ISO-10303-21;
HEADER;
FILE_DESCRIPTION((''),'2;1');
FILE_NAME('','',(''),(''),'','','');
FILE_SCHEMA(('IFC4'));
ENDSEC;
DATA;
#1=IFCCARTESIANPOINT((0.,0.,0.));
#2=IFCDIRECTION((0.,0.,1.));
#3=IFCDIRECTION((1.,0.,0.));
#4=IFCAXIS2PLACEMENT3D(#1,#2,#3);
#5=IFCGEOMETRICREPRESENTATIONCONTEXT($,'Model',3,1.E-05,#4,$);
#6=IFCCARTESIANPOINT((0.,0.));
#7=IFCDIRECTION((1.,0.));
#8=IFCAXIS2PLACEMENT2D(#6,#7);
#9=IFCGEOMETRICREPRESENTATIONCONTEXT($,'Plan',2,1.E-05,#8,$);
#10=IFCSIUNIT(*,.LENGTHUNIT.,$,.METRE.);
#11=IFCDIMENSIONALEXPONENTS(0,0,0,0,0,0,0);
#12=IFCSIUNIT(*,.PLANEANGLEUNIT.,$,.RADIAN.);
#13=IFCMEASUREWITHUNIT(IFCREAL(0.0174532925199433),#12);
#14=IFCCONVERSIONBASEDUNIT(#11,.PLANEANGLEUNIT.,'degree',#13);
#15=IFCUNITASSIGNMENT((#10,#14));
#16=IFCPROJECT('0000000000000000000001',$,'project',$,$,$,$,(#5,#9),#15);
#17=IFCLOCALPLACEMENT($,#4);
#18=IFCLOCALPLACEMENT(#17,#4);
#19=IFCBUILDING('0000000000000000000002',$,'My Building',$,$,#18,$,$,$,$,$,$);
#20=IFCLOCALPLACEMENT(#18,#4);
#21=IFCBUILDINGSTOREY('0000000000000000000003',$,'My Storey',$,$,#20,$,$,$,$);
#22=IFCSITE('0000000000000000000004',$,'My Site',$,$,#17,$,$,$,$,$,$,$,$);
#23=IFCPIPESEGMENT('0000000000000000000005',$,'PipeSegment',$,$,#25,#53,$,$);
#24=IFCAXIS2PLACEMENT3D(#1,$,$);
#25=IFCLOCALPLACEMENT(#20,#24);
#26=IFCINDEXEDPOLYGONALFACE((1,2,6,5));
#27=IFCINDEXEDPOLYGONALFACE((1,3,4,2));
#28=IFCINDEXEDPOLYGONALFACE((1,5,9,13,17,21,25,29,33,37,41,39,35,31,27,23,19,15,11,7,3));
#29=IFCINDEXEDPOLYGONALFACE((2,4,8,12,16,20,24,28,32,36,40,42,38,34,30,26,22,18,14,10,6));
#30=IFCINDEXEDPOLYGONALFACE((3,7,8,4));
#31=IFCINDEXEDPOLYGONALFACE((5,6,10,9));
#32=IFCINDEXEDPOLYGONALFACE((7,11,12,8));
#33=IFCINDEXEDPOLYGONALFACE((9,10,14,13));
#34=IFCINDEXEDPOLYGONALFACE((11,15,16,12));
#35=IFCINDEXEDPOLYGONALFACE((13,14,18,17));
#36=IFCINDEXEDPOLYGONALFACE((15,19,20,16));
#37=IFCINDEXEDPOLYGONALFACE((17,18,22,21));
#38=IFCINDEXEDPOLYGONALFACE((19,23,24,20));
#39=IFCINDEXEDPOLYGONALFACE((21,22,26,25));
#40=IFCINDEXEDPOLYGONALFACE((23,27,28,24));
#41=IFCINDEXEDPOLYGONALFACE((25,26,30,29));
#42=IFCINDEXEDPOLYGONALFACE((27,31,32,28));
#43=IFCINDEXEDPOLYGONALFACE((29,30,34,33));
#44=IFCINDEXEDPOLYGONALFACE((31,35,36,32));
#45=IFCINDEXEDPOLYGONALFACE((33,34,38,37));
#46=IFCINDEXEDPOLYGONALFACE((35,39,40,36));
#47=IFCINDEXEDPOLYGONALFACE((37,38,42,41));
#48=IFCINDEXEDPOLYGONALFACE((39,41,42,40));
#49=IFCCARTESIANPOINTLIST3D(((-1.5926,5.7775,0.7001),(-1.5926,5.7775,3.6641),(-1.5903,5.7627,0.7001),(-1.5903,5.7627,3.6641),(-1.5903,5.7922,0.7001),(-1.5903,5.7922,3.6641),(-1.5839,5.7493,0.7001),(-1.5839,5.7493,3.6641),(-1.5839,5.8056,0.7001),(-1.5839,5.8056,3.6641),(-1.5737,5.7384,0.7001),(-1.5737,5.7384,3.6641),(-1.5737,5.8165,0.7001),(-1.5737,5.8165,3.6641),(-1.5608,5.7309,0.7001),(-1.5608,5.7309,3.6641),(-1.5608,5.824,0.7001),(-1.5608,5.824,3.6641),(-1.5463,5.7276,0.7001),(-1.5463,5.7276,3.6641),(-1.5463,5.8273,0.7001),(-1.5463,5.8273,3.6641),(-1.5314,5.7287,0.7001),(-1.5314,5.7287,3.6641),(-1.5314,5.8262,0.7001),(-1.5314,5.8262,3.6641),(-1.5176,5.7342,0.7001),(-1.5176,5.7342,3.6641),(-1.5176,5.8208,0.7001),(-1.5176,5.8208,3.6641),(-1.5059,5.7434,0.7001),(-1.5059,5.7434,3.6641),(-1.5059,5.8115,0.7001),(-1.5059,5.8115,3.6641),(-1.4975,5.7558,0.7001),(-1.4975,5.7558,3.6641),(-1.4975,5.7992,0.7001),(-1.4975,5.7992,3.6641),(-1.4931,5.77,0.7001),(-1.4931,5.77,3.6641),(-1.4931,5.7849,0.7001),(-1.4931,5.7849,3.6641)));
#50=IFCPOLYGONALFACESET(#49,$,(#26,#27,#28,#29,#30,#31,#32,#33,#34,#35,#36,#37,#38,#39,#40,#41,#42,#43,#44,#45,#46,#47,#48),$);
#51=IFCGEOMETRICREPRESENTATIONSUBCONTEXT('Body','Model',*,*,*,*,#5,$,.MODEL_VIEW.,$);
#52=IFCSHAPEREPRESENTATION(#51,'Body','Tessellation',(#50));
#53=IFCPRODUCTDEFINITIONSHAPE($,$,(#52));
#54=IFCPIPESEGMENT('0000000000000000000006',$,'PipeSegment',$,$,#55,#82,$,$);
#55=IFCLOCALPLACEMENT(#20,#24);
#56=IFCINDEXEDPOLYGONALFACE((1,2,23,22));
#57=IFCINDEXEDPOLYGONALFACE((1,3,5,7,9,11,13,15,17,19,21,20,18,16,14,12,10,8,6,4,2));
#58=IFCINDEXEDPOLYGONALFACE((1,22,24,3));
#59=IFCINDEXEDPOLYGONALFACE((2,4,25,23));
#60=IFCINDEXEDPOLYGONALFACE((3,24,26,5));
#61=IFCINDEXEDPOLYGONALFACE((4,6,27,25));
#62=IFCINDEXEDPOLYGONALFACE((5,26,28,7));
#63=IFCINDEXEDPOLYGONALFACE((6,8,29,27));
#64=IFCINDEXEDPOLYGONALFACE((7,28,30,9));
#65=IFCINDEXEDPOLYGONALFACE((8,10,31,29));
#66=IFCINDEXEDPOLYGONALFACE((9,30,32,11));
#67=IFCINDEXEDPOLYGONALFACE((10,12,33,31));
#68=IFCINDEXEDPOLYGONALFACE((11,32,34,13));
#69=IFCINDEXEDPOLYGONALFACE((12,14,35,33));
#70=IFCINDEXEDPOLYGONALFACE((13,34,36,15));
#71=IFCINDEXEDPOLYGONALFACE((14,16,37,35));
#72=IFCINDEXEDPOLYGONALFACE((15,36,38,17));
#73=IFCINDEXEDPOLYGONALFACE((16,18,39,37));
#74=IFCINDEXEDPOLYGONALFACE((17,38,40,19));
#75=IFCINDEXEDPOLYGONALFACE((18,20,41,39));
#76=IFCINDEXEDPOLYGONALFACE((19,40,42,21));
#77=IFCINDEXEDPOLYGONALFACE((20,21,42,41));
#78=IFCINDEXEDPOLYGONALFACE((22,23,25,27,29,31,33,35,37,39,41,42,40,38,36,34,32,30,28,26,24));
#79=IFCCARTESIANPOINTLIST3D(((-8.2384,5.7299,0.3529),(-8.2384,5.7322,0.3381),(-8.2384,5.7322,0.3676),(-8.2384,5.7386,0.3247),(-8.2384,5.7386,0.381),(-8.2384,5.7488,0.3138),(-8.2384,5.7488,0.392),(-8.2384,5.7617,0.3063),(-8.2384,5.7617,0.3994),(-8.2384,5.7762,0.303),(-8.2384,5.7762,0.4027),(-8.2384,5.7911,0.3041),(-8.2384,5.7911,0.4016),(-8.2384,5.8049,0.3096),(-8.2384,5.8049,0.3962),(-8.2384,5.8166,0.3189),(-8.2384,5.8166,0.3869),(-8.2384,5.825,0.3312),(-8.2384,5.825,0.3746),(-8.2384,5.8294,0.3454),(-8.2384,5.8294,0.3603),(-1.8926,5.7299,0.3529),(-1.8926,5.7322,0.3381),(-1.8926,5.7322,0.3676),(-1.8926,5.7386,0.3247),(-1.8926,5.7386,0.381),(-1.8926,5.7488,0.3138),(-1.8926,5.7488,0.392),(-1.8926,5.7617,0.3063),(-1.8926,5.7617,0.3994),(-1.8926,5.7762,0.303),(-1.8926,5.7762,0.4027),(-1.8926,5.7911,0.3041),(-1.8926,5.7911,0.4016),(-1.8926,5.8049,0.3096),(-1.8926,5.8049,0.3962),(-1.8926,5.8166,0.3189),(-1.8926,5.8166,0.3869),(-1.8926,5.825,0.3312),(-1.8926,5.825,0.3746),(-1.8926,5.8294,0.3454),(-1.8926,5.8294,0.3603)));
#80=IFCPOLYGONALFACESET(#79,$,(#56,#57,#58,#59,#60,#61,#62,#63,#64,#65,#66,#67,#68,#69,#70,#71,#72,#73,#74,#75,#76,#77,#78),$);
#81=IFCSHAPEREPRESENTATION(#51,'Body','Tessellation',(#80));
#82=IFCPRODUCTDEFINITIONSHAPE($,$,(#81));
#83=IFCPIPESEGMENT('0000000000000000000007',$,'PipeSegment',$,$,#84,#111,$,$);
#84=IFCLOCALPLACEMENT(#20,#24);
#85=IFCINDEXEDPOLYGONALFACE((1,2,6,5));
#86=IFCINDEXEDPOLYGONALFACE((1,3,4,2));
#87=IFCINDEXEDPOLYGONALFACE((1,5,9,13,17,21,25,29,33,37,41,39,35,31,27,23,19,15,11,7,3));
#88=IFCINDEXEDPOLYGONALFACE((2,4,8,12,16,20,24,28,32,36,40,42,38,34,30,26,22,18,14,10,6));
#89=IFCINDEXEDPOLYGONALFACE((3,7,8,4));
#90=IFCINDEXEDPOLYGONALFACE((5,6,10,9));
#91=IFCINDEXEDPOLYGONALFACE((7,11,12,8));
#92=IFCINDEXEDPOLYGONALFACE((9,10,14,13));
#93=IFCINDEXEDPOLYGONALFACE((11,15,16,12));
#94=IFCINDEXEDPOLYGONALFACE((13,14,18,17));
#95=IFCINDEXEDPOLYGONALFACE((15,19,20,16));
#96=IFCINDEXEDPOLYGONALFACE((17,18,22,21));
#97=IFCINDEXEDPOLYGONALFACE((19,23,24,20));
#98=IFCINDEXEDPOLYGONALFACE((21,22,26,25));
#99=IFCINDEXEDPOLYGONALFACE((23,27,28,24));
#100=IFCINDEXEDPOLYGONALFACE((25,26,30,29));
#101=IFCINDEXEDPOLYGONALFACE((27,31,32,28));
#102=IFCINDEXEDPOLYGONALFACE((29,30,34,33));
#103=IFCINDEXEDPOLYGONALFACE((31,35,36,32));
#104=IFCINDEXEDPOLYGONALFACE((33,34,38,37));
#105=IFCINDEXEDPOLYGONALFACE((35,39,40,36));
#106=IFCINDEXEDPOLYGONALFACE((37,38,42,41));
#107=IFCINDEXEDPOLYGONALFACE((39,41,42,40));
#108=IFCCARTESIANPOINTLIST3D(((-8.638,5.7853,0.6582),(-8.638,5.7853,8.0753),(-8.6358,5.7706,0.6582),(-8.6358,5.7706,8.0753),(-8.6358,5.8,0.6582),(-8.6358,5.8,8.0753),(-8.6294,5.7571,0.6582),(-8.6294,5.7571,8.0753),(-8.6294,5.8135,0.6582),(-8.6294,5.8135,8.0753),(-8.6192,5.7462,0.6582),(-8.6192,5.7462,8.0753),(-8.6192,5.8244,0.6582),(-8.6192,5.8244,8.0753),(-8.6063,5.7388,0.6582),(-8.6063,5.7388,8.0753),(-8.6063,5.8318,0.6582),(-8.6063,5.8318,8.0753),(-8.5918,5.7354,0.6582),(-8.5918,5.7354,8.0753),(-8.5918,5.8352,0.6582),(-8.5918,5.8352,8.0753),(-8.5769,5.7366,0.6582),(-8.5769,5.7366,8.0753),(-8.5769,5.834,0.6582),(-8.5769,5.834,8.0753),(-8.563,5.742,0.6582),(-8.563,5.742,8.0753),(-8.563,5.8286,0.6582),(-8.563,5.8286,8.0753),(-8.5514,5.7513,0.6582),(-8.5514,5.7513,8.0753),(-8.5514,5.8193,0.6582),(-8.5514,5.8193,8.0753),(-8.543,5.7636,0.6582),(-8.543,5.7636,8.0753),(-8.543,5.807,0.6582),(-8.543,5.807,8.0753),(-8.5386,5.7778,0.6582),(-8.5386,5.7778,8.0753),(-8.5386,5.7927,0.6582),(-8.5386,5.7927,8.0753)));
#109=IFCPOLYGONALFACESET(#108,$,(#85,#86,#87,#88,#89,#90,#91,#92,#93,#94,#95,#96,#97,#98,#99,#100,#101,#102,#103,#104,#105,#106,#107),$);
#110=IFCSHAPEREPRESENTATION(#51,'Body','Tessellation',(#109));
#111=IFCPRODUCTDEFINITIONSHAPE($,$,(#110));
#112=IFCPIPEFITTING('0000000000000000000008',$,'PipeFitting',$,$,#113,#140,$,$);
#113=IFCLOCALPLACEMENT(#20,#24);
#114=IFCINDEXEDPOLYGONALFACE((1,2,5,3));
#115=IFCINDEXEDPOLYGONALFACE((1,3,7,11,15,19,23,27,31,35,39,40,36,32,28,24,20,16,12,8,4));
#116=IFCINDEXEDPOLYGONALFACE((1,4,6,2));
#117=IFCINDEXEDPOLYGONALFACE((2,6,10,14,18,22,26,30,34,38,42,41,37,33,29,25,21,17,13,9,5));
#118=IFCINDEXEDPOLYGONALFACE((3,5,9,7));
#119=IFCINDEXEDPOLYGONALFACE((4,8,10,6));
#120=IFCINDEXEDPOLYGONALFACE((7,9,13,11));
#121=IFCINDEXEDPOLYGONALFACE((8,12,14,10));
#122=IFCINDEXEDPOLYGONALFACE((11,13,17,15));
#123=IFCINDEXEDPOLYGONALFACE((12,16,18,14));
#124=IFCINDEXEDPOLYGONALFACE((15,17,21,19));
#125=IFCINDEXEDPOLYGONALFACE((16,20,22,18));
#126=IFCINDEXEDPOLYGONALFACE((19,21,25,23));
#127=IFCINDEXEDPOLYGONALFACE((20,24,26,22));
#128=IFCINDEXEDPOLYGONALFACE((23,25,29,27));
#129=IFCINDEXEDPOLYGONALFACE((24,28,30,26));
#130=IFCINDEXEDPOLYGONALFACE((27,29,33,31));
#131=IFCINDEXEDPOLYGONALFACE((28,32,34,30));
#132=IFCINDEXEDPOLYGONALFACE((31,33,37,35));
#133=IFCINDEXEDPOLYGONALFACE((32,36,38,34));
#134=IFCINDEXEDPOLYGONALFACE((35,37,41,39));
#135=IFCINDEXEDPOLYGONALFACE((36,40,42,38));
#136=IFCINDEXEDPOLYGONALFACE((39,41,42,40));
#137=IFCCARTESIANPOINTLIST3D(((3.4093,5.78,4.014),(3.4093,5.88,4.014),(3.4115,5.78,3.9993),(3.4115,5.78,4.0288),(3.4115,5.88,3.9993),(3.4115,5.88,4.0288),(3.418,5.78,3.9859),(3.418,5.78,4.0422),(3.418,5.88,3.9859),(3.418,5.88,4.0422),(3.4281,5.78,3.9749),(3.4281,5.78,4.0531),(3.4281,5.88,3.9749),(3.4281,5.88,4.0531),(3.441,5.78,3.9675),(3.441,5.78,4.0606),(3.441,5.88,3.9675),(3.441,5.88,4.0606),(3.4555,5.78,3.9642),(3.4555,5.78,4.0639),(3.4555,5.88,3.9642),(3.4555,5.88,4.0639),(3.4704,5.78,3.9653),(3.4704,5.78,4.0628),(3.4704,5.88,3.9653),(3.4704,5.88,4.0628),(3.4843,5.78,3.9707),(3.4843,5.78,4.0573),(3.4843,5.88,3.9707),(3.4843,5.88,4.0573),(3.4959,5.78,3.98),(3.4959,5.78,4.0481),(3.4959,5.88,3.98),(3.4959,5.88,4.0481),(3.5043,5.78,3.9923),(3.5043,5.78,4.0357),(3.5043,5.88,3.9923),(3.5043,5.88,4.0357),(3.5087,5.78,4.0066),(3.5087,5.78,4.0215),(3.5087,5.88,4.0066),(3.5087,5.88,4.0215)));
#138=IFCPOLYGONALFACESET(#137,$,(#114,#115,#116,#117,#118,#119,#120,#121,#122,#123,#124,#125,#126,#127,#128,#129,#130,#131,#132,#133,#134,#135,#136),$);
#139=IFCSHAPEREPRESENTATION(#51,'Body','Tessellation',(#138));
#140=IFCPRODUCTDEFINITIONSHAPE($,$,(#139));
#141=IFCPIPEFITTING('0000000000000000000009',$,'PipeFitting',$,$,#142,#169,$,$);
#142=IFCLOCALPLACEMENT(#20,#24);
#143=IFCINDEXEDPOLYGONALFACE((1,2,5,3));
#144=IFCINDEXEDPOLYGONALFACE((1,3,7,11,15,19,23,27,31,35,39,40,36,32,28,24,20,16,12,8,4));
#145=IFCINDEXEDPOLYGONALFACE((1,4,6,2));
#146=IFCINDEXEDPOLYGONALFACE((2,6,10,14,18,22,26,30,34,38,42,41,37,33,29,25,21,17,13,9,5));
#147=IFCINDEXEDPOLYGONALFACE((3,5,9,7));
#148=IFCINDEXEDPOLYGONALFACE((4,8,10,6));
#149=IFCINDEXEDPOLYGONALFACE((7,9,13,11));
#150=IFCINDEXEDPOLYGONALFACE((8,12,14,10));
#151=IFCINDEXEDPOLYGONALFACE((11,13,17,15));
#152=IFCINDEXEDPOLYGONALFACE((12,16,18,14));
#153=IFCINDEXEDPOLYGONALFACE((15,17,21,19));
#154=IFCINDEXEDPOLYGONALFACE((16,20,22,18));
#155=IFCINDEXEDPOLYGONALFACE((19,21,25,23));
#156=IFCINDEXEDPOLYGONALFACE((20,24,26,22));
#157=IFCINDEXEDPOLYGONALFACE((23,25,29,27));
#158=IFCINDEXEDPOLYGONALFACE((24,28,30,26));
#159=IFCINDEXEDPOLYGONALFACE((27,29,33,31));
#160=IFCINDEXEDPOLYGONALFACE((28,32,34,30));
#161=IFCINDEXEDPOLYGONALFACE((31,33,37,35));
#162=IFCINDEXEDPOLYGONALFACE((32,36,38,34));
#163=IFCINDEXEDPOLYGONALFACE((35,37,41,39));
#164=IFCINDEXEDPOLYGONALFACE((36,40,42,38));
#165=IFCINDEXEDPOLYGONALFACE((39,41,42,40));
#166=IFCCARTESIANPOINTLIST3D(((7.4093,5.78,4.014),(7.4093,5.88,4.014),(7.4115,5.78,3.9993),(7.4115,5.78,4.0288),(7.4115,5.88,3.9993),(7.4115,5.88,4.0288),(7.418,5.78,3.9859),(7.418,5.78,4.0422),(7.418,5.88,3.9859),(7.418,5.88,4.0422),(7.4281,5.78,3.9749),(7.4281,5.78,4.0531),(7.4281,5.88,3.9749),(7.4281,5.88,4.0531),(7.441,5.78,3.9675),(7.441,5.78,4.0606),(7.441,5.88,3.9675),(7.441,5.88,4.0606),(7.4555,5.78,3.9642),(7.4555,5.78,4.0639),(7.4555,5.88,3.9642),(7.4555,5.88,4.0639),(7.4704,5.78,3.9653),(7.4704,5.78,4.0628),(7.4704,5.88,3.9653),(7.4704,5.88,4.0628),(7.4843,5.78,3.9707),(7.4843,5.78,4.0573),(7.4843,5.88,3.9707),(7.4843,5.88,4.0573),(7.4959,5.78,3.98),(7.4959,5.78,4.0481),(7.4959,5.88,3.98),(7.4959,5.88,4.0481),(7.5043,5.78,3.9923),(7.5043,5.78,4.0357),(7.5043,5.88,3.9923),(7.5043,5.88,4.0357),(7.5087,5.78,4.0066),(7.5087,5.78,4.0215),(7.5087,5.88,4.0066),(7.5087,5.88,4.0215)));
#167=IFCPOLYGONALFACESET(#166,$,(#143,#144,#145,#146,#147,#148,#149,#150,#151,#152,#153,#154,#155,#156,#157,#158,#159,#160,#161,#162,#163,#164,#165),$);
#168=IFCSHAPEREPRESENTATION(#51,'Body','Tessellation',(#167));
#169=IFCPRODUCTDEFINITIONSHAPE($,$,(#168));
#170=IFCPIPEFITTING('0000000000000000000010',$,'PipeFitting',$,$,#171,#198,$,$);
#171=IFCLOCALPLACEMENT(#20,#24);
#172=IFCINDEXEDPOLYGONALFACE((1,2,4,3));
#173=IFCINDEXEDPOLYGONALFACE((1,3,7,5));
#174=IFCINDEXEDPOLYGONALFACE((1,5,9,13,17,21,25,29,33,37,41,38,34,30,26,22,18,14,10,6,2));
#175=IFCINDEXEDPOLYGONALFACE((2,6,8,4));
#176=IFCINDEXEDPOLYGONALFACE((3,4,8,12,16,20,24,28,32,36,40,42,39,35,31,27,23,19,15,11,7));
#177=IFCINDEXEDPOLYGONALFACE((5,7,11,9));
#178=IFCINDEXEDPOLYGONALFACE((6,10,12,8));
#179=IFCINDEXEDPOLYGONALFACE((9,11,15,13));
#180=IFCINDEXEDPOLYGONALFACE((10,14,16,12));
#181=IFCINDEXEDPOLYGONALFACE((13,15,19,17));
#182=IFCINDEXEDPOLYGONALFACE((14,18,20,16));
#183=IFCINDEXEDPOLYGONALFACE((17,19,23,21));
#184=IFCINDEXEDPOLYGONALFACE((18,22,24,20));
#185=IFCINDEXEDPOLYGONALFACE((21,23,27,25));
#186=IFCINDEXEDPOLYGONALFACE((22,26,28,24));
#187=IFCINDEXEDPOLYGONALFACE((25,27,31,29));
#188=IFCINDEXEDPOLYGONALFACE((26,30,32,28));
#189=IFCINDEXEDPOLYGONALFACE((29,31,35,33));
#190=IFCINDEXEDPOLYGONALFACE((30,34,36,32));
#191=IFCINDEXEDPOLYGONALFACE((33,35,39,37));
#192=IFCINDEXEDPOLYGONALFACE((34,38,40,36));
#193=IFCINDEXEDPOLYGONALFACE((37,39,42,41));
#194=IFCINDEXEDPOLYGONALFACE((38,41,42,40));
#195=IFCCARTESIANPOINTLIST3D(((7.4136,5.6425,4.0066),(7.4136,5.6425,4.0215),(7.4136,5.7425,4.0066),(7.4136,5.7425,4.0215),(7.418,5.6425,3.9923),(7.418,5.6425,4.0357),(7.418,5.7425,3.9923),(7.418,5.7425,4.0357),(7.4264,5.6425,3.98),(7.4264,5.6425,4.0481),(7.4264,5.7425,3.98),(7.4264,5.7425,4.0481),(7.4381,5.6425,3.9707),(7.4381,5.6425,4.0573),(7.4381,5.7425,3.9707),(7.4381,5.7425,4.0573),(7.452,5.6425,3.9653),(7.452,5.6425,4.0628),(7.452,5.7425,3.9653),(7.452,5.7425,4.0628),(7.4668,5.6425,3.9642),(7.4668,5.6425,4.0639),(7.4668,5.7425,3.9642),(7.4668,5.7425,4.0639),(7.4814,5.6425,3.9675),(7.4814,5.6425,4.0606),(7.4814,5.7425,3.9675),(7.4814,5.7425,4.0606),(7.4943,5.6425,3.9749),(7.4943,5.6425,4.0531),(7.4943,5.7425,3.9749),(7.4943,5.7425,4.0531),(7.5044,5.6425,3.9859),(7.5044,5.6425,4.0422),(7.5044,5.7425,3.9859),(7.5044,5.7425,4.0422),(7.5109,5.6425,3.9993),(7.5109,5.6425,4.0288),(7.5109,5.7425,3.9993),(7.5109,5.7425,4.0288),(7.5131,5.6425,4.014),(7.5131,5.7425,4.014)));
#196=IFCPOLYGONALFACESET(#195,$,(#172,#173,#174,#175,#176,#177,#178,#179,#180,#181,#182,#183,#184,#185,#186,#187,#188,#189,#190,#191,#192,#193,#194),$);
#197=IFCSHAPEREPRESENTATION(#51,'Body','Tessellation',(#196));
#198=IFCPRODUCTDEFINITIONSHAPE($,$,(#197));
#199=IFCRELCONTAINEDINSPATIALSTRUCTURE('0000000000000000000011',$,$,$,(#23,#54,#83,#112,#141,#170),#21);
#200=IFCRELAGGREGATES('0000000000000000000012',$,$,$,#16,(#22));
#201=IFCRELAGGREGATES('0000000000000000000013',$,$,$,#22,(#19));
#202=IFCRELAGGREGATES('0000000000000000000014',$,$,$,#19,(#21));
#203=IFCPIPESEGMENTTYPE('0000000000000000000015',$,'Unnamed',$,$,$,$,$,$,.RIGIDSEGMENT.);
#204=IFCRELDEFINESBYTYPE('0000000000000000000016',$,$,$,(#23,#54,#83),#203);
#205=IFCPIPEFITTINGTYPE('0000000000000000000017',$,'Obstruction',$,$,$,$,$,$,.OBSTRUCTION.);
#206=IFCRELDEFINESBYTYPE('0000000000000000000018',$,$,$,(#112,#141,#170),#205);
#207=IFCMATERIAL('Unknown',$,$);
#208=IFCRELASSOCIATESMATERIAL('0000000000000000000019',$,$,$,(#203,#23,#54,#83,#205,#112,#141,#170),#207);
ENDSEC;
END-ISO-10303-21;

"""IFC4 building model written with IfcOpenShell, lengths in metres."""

from ifc_helpers import new_model, entity, si_unit, converted_unit, frame, origin_with_axes, origin_2d_with_axis, place, context, subcontext, project, spatial, circle, extrude, material, material_profile, profile_set, profile_usage, type_object, element, save


model = new_model("IFC4")

# Units and contexts
model_context = context("Model", 3, precision=1e-05, world=origin_with_axes())
plan_context = context("Plan", 2, precision=1e-05, world=origin_2d_with_axis())
body_context = subcontext(model_context, "Body", "Model", "MODEL_VIEW")
ifc_project = project(units=[si_unit("LENGTHUNIT", "METRE"), converted_unit("PLANEANGLEUNIT", "degree", entity("IfcReal", 0.0174532925199433), si_unit("PLANEANGLEUNIT", "RADIAN"), dimensions=[0, 0, 0, 0, 0, 0, 0])], contexts=[model_context, plan_context])

# Site, building, storey
site_placement = place(None, origin_with_axes())
site = spatial("IfcSite", under=ifc_project, at=site_placement, Name="My Site")
building_placement = place(site_placement, origin_with_axes())
building = spatial("IfcBuilding", under=site, at=building_placement, Name="My Building")
storey_placement = place(building_placement, origin_with_axes())
storey = spatial("IfcBuildingStorey", under=building, at=storey_placement, Name="My Storey")

# Shared definitions
ifc_material = material(Name="Unknown")

# Pipe segments
ifc_material_profile_1 = material_profile(ifc_material, circle(Radius=0.05))
ifc_profile_set_1 = profile_set([ifc_material_profile_1])
pipe_segment_type = type_object("IfcPipeSegmentType", Name="Unnamed", PredefinedType="RIGIDSEGMENT", material=ifc_profile_set_1)
ifc_profile_usage_1 = profile_usage(ifc_profile_set_1, cardinal=5)
pipe_segment_1_placement = place(storey_placement, frame((-1.5426, 5.7775, 3.6641), z_axis=(0.0, 0.0, -1.0), x_axis=(-1.0, 0.0, 0.0)))
element("IfcPipeSegment", 1, at=pipe_segment_1_placement, inside=storey, type_object=pipe_segment_type, material=ifc_profile_usage_1, Name="PipeSegment", context=body_context, shape_type="SweptSolid", body=[
    extrude(circle(Radius=0.05), origin_with_axes(), (0.0, 0.0, 1.0), 2.964),
])
ifc_profile_usage_2 = profile_usage(ifc_profile_set_1, cardinal=5)
pipe_segment_2_placement = place(storey_placement, frame((-1.8926, 5.7799, 0.3529), z_axis=(-1.0, 0.0, 0.0), x_axis=(0.0, -1.0, 0.0)))
element("IfcPipeSegment", 2, at=pipe_segment_2_placement, inside=storey, type_object=pipe_segment_type, material=ifc_profile_usage_2, Name="PipeSegment", context=body_context, shape_type="SweptSolid", body=[
    extrude(circle(Radius=0.05), origin_with_axes(), (0.0, 0.0, 1.0), 6.3458),
])
ifc_profile_usage_3 = profile_usage(ifc_profile_set_1, cardinal=5)
pipe_segment_3_placement = place(storey_placement, frame((-8.588, 5.7853, 0.6582), z_axis=(0.0, 0.0, 1.0), x_axis=(-1.0, 0.0, 0.0)))
element("IfcPipeSegment", 3, at=pipe_segment_3_placement, inside=storey, type_object=pipe_segment_type, material=ifc_profile_usage_3, Name="PipeSegment", context=body_context, shape_type="SweptSolid", body=[
    extrude(circle(Radius=0.05), origin_with_axes(), (0.0, 0.0, 1.0), 7.417),
])

# Pipe fittings
ifc_material_profile_2 = material_profile(ifc_material, circle(Radius=0.05))
ifc_profile_set_2 = profile_set([ifc_material_profile_2])
ifc_profile_usage_4 = profile_usage(ifc_profile_set_2, cardinal=5)
pipe_fitting_type_1 = type_object("IfcPipeFittingType", Name="Obstruction", PredefinedType="OBSTRUCTION", material=ifc_profile_set_2)
pipe_fitting_1_placement = place(storey_placement, frame((3.4593, 5.78, 4.014), z_axis=(0.0, 1.0, 0.0), x_axis=(-1.0, 0.0, 0.0)))
element("IfcPipeFitting", 4, at=pipe_fitting_1_placement, inside=storey, type_object=pipe_fitting_type_1, material=ifc_profile_usage_4, Name="PipeFitting", context=body_context, shape_type="SweptSolid", body=[
    extrude(circle(Radius=0.05), origin_with_axes(), (0.0, 0.0, 1.0), 0.1),
])
ifc_profile_usage_5 = profile_usage(ifc_profile_set_2, cardinal=5)
pipe_fitting_2_placement = place(storey_placement, frame((7.4593, 5.78, 4.014), z_axis=(0.0, 1.0, 0.0), x_axis=(-1.0, 0.0, 0.0)))
element("IfcPipeFitting", 5, at=pipe_fitting_2_placement, inside=storey, type_object=pipe_fitting_type_1, material=ifc_profile_usage_5, Name="PipeFitting", context=body_context, shape_type="SweptSolid", body=[
    extrude(circle(Radius=0.05), origin_with_axes(), (0.0, 0.0, 1.0), 0.1),
])
ifc_profile_usage_6 = profile_usage(ifc_profile_set_2, cardinal=5)
pipe_fitting_3_placement = place(storey_placement, frame((7.4631, 5.7425, 4.014), z_axis=(0.0, -1.0, 0.0), x_axis=(1.0, 0.0, 0.0)))
element("IfcPipeFitting", 6, at=pipe_fitting_3_placement, inside=storey, type_object=pipe_fitting_type_1, material=ifc_profile_usage_6, Name="PipeFitting", context=body_context, shape_type="SweptSolid", body=[
    extrude(circle(Radius=0.05), origin_with_axes(), (0.0, 0.0, 1.0), 0.1),
])

save(model, "model.ifc")
